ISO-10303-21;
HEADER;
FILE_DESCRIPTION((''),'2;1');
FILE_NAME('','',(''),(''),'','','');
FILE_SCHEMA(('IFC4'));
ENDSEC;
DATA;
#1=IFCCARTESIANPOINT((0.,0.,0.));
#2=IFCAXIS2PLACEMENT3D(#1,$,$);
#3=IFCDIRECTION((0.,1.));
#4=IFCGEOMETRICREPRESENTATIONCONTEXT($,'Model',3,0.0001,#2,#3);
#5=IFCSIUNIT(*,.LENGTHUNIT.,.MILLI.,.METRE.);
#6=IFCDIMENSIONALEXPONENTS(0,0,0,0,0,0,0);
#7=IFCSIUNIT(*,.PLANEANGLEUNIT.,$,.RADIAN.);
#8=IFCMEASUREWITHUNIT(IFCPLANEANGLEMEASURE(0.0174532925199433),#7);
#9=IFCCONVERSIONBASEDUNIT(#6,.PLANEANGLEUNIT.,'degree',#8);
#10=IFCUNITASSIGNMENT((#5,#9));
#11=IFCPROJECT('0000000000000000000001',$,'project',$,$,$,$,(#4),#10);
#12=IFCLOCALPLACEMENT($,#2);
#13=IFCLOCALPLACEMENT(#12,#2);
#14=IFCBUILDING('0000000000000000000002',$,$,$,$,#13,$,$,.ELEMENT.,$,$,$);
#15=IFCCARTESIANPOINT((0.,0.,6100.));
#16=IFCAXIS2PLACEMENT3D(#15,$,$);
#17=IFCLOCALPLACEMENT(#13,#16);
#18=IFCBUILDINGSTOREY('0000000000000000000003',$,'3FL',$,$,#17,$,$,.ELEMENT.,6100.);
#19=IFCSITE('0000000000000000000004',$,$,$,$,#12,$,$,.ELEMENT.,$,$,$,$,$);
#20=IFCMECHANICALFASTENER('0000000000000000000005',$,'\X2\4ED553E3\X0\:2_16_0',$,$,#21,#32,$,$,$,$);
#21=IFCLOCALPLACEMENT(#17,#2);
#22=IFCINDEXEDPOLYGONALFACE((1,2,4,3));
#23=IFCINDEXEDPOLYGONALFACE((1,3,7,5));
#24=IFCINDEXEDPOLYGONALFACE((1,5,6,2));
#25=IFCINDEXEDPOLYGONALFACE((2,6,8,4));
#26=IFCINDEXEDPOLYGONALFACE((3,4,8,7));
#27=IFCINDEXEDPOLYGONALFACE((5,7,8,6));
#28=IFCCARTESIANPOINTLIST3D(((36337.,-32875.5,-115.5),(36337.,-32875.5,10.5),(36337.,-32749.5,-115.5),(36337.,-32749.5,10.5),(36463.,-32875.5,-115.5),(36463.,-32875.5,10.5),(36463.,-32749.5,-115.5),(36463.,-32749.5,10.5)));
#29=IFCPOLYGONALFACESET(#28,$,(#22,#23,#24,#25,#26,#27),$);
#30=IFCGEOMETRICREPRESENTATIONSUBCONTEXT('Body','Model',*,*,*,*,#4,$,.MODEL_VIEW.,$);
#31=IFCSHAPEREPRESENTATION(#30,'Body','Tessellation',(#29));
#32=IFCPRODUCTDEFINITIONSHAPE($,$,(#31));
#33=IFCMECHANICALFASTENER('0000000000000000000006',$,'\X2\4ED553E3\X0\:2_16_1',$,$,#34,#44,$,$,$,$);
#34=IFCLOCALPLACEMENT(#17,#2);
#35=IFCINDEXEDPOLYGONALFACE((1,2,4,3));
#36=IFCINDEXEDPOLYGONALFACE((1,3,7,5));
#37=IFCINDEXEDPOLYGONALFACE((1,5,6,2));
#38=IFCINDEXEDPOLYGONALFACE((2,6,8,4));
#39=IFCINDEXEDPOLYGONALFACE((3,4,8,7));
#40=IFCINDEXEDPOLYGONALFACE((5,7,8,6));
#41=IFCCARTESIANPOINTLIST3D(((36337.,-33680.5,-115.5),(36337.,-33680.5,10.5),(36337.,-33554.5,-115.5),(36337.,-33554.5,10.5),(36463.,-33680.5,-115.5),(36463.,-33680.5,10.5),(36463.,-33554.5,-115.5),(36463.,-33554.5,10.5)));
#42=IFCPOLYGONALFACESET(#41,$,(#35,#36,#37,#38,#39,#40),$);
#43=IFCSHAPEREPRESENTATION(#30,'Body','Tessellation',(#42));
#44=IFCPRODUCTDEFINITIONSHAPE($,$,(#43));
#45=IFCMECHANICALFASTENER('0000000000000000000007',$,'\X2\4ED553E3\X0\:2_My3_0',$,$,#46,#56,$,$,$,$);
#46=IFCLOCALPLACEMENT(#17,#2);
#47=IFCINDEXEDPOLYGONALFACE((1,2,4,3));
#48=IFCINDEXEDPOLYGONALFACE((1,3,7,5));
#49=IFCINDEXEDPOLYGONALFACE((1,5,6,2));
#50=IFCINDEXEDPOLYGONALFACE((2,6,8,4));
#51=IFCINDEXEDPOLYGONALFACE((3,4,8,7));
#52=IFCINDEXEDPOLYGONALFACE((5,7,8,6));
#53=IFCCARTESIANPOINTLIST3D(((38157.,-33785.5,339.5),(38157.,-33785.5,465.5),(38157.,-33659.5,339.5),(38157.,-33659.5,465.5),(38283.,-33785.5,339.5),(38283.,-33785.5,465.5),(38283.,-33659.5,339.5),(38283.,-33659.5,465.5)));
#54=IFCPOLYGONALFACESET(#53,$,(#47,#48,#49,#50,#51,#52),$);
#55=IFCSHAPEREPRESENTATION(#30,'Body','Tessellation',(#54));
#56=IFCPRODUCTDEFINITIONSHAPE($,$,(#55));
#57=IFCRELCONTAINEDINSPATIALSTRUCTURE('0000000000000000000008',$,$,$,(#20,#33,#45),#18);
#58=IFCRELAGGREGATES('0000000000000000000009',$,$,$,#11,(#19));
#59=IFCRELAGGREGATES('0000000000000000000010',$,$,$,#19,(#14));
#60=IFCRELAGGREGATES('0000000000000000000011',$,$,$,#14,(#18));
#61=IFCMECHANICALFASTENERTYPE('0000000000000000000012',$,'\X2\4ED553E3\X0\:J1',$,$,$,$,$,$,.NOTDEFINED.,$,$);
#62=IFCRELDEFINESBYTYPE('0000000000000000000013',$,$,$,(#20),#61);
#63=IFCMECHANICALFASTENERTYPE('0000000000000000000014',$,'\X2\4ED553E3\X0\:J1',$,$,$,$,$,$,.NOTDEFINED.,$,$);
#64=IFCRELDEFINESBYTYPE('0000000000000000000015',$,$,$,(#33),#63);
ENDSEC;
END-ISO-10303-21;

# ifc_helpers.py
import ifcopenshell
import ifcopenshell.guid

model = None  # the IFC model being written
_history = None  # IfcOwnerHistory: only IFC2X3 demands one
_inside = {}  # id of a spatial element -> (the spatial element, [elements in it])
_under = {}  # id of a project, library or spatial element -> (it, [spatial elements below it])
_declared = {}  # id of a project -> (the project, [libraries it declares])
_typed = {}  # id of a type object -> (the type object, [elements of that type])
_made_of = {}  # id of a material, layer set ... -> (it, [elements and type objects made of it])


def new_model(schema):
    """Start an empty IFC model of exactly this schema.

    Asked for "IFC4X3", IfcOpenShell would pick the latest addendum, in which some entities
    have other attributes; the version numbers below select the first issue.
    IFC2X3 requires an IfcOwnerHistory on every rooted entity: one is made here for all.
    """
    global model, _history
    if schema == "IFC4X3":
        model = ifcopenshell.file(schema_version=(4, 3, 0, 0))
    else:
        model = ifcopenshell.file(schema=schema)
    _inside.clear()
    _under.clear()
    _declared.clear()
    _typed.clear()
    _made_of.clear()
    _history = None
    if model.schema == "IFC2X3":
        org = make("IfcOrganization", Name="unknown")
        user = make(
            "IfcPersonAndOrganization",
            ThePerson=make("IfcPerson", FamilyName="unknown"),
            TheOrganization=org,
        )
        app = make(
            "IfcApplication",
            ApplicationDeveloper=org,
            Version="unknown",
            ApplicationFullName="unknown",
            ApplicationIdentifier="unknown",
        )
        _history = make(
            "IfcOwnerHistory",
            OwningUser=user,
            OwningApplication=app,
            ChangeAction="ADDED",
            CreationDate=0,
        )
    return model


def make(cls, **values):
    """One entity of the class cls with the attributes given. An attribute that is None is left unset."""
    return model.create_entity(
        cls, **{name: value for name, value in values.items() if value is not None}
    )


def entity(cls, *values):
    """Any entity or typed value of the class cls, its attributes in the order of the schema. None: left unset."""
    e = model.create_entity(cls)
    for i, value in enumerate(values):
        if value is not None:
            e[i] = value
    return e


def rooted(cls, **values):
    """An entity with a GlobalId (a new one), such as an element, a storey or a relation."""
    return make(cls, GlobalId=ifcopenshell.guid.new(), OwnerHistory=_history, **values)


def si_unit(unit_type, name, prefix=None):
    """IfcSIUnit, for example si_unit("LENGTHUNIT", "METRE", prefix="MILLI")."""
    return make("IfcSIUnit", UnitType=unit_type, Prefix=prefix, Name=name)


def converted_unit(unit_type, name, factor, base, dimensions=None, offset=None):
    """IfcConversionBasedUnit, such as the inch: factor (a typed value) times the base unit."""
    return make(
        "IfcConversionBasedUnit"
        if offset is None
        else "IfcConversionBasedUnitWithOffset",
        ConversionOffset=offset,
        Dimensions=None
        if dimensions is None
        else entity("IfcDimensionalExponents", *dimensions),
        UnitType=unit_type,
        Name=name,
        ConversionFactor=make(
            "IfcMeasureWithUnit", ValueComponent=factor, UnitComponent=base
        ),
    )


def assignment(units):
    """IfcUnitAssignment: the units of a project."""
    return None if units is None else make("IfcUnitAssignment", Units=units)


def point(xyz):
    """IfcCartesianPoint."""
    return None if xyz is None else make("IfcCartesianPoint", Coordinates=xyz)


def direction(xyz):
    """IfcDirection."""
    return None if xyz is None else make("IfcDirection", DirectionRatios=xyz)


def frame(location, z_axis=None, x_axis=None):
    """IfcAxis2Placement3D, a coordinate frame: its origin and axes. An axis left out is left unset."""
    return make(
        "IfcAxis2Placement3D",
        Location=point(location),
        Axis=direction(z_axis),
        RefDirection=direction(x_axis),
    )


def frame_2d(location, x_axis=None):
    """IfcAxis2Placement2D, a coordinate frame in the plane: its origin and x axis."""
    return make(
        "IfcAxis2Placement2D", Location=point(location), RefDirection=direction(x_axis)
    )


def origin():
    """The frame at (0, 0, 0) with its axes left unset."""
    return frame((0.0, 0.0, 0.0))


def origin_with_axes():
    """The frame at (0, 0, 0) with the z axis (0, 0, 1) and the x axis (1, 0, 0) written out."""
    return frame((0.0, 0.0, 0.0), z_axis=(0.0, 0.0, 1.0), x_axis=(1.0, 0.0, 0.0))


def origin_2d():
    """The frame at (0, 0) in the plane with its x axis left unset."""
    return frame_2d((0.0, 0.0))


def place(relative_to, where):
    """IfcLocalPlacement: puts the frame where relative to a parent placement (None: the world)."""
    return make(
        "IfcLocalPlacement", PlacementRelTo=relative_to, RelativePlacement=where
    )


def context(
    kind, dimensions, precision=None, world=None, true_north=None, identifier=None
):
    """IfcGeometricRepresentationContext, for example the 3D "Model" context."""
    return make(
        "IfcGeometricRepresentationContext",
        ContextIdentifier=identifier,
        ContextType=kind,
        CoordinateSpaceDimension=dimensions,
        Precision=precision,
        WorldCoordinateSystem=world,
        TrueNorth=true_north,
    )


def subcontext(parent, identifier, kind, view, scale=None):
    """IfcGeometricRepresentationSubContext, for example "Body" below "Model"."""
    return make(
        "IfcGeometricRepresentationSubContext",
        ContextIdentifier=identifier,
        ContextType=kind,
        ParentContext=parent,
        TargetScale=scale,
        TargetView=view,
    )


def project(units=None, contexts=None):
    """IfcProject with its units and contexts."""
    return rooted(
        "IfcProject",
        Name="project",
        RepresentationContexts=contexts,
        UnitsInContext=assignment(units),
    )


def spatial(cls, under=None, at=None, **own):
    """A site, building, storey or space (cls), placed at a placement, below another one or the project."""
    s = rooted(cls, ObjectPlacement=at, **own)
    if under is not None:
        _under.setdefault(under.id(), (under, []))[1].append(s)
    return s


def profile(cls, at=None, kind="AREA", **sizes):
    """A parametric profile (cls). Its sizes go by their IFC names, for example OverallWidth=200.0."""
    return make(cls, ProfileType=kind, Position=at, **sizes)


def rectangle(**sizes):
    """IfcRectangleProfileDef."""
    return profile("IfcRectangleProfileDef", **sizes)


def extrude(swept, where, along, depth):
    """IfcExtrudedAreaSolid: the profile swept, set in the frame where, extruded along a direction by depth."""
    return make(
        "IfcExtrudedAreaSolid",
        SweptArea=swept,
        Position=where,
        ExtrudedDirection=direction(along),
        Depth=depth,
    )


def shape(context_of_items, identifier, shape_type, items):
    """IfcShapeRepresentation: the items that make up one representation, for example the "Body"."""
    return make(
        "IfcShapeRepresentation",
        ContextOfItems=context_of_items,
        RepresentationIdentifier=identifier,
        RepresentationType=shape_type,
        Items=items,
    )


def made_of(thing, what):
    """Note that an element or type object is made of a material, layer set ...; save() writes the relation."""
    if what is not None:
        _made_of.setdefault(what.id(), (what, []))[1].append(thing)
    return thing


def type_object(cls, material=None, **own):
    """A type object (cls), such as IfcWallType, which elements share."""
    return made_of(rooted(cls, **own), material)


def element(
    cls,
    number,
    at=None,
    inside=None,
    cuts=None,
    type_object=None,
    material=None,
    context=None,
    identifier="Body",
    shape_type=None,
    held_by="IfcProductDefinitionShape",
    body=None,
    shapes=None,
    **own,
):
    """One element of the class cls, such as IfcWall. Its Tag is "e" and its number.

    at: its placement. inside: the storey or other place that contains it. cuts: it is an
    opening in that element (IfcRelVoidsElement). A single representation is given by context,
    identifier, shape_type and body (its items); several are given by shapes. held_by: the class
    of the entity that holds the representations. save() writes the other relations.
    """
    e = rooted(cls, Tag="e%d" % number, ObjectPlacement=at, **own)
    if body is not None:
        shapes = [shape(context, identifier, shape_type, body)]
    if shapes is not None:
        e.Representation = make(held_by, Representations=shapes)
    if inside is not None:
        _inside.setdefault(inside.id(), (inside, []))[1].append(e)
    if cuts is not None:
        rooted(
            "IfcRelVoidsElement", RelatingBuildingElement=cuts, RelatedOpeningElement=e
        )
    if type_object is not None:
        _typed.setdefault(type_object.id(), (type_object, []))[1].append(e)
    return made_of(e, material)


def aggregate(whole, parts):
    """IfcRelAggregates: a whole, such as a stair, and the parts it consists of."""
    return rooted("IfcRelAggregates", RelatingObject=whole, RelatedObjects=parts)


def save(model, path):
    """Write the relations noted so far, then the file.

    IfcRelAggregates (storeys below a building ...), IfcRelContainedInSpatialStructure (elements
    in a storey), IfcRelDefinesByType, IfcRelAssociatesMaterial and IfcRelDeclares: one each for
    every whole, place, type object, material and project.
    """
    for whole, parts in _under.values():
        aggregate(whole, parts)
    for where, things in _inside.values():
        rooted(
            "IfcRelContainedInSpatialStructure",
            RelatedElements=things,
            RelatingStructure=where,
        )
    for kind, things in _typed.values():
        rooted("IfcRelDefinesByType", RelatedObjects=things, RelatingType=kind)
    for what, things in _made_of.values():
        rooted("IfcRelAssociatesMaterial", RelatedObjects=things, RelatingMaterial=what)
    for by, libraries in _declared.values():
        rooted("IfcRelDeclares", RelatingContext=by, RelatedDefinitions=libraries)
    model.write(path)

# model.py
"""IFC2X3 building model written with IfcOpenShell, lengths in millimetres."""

from ifc_helpers import new_model, entity, si_unit, converted_unit, direction, frame, origin, origin_with_axes, origin_2d, place, context, subcontext, project, spatial, rectangle, extrude, type_object, element, save


model = new_model("IFC2X3")

# Units and contexts
model_context = context("Model", 3, precision=0.0001, world=origin(), true_north=direction((0.0, 1.0)))
body_context = subcontext(model_context, "Body", "Model", "MODEL_VIEW")
ifc_project = project(units=[si_unit("LENGTHUNIT", "METRE", prefix="MILLI"), converted_unit("PLANEANGLEUNIT", "degree", entity("IfcPlaneAngleMeasure", 0.0174532925199433), si_unit("PLANEANGLEUNIT", "RADIAN"), dimensions=[0, 0, 0, 0, 0, 0, 0])], contexts=[model_context])

# Site, building, storey
site_placement = place(None, origin())
site = spatial("IfcSite", under=ifc_project, at=site_placement, CompositionType="ELEMENT")
building_placement = place(site_placement, origin())
building = spatial("IfcBuilding", under=site, at=building_placement, CompositionType="ELEMENT")
storey_placement = place(building_placement, frame((0.0, 0.0, 6100.0)))
storey = spatial("IfcBuildingStorey", under=building, at=storey_placement, Name="3FL", CompositionType="ELEMENT", Elevation=6100.0)

# Mechanical fasteners
mechanical_fastener_type_1 = type_object("IfcMechanicalFastenerType", Name="仕口:J1")
mechanical_fastener_1_placement = place(storey_placement, frame((36400.0, -32812.5, -115.5)))
element("IfcMechanicalFastener", 1, at=mechanical_fastener_1_placement, inside=storey, type_object=mechanical_fastener_type_1, Name="仕口:2_16_0", context=body_context, shape_type="SweptSolid", body=[
    extrude(rectangle(XDim=126.0, YDim=126.0, at=origin_2d()), origin_with_axes(), (0.0, 0.0, 1.0), 126.0),
])
mechanical_fastener_type_2 = type_object("IfcMechanicalFastenerType", Name="仕口:J1")
mechanical_fastener_2_placement = place(storey_placement, frame((36400.0, -33617.5, -115.5)))
element("IfcMechanicalFastener", 2, at=mechanical_fastener_2_placement, inside=storey, type_object=mechanical_fastener_type_2, Name="仕口:2_16_1", context=body_context, shape_type="SweptSolid", body=[
    extrude(rectangle(XDim=126.0, YDim=126.0, at=origin_2d()), origin_with_axes(), (0.0, 0.0, 1.0), 126.0),
])
mechanical_fastener_3_placement = place(storey_placement, frame((38220.0, -33722.5, 339.5)))
element("IfcMechanicalFastener", 3, at=mechanical_fastener_3_placement, inside=storey, Name="仕口:2_My3_0", context=body_context, shape_type="SweptSolid", body=[
    extrude(rectangle(XDim=126.0, YDim=126.0, at=origin_2d()), origin_with_axes(), (0.0, 0.0, 1.0), 126.0),
])

save(model, "model.ifc")
